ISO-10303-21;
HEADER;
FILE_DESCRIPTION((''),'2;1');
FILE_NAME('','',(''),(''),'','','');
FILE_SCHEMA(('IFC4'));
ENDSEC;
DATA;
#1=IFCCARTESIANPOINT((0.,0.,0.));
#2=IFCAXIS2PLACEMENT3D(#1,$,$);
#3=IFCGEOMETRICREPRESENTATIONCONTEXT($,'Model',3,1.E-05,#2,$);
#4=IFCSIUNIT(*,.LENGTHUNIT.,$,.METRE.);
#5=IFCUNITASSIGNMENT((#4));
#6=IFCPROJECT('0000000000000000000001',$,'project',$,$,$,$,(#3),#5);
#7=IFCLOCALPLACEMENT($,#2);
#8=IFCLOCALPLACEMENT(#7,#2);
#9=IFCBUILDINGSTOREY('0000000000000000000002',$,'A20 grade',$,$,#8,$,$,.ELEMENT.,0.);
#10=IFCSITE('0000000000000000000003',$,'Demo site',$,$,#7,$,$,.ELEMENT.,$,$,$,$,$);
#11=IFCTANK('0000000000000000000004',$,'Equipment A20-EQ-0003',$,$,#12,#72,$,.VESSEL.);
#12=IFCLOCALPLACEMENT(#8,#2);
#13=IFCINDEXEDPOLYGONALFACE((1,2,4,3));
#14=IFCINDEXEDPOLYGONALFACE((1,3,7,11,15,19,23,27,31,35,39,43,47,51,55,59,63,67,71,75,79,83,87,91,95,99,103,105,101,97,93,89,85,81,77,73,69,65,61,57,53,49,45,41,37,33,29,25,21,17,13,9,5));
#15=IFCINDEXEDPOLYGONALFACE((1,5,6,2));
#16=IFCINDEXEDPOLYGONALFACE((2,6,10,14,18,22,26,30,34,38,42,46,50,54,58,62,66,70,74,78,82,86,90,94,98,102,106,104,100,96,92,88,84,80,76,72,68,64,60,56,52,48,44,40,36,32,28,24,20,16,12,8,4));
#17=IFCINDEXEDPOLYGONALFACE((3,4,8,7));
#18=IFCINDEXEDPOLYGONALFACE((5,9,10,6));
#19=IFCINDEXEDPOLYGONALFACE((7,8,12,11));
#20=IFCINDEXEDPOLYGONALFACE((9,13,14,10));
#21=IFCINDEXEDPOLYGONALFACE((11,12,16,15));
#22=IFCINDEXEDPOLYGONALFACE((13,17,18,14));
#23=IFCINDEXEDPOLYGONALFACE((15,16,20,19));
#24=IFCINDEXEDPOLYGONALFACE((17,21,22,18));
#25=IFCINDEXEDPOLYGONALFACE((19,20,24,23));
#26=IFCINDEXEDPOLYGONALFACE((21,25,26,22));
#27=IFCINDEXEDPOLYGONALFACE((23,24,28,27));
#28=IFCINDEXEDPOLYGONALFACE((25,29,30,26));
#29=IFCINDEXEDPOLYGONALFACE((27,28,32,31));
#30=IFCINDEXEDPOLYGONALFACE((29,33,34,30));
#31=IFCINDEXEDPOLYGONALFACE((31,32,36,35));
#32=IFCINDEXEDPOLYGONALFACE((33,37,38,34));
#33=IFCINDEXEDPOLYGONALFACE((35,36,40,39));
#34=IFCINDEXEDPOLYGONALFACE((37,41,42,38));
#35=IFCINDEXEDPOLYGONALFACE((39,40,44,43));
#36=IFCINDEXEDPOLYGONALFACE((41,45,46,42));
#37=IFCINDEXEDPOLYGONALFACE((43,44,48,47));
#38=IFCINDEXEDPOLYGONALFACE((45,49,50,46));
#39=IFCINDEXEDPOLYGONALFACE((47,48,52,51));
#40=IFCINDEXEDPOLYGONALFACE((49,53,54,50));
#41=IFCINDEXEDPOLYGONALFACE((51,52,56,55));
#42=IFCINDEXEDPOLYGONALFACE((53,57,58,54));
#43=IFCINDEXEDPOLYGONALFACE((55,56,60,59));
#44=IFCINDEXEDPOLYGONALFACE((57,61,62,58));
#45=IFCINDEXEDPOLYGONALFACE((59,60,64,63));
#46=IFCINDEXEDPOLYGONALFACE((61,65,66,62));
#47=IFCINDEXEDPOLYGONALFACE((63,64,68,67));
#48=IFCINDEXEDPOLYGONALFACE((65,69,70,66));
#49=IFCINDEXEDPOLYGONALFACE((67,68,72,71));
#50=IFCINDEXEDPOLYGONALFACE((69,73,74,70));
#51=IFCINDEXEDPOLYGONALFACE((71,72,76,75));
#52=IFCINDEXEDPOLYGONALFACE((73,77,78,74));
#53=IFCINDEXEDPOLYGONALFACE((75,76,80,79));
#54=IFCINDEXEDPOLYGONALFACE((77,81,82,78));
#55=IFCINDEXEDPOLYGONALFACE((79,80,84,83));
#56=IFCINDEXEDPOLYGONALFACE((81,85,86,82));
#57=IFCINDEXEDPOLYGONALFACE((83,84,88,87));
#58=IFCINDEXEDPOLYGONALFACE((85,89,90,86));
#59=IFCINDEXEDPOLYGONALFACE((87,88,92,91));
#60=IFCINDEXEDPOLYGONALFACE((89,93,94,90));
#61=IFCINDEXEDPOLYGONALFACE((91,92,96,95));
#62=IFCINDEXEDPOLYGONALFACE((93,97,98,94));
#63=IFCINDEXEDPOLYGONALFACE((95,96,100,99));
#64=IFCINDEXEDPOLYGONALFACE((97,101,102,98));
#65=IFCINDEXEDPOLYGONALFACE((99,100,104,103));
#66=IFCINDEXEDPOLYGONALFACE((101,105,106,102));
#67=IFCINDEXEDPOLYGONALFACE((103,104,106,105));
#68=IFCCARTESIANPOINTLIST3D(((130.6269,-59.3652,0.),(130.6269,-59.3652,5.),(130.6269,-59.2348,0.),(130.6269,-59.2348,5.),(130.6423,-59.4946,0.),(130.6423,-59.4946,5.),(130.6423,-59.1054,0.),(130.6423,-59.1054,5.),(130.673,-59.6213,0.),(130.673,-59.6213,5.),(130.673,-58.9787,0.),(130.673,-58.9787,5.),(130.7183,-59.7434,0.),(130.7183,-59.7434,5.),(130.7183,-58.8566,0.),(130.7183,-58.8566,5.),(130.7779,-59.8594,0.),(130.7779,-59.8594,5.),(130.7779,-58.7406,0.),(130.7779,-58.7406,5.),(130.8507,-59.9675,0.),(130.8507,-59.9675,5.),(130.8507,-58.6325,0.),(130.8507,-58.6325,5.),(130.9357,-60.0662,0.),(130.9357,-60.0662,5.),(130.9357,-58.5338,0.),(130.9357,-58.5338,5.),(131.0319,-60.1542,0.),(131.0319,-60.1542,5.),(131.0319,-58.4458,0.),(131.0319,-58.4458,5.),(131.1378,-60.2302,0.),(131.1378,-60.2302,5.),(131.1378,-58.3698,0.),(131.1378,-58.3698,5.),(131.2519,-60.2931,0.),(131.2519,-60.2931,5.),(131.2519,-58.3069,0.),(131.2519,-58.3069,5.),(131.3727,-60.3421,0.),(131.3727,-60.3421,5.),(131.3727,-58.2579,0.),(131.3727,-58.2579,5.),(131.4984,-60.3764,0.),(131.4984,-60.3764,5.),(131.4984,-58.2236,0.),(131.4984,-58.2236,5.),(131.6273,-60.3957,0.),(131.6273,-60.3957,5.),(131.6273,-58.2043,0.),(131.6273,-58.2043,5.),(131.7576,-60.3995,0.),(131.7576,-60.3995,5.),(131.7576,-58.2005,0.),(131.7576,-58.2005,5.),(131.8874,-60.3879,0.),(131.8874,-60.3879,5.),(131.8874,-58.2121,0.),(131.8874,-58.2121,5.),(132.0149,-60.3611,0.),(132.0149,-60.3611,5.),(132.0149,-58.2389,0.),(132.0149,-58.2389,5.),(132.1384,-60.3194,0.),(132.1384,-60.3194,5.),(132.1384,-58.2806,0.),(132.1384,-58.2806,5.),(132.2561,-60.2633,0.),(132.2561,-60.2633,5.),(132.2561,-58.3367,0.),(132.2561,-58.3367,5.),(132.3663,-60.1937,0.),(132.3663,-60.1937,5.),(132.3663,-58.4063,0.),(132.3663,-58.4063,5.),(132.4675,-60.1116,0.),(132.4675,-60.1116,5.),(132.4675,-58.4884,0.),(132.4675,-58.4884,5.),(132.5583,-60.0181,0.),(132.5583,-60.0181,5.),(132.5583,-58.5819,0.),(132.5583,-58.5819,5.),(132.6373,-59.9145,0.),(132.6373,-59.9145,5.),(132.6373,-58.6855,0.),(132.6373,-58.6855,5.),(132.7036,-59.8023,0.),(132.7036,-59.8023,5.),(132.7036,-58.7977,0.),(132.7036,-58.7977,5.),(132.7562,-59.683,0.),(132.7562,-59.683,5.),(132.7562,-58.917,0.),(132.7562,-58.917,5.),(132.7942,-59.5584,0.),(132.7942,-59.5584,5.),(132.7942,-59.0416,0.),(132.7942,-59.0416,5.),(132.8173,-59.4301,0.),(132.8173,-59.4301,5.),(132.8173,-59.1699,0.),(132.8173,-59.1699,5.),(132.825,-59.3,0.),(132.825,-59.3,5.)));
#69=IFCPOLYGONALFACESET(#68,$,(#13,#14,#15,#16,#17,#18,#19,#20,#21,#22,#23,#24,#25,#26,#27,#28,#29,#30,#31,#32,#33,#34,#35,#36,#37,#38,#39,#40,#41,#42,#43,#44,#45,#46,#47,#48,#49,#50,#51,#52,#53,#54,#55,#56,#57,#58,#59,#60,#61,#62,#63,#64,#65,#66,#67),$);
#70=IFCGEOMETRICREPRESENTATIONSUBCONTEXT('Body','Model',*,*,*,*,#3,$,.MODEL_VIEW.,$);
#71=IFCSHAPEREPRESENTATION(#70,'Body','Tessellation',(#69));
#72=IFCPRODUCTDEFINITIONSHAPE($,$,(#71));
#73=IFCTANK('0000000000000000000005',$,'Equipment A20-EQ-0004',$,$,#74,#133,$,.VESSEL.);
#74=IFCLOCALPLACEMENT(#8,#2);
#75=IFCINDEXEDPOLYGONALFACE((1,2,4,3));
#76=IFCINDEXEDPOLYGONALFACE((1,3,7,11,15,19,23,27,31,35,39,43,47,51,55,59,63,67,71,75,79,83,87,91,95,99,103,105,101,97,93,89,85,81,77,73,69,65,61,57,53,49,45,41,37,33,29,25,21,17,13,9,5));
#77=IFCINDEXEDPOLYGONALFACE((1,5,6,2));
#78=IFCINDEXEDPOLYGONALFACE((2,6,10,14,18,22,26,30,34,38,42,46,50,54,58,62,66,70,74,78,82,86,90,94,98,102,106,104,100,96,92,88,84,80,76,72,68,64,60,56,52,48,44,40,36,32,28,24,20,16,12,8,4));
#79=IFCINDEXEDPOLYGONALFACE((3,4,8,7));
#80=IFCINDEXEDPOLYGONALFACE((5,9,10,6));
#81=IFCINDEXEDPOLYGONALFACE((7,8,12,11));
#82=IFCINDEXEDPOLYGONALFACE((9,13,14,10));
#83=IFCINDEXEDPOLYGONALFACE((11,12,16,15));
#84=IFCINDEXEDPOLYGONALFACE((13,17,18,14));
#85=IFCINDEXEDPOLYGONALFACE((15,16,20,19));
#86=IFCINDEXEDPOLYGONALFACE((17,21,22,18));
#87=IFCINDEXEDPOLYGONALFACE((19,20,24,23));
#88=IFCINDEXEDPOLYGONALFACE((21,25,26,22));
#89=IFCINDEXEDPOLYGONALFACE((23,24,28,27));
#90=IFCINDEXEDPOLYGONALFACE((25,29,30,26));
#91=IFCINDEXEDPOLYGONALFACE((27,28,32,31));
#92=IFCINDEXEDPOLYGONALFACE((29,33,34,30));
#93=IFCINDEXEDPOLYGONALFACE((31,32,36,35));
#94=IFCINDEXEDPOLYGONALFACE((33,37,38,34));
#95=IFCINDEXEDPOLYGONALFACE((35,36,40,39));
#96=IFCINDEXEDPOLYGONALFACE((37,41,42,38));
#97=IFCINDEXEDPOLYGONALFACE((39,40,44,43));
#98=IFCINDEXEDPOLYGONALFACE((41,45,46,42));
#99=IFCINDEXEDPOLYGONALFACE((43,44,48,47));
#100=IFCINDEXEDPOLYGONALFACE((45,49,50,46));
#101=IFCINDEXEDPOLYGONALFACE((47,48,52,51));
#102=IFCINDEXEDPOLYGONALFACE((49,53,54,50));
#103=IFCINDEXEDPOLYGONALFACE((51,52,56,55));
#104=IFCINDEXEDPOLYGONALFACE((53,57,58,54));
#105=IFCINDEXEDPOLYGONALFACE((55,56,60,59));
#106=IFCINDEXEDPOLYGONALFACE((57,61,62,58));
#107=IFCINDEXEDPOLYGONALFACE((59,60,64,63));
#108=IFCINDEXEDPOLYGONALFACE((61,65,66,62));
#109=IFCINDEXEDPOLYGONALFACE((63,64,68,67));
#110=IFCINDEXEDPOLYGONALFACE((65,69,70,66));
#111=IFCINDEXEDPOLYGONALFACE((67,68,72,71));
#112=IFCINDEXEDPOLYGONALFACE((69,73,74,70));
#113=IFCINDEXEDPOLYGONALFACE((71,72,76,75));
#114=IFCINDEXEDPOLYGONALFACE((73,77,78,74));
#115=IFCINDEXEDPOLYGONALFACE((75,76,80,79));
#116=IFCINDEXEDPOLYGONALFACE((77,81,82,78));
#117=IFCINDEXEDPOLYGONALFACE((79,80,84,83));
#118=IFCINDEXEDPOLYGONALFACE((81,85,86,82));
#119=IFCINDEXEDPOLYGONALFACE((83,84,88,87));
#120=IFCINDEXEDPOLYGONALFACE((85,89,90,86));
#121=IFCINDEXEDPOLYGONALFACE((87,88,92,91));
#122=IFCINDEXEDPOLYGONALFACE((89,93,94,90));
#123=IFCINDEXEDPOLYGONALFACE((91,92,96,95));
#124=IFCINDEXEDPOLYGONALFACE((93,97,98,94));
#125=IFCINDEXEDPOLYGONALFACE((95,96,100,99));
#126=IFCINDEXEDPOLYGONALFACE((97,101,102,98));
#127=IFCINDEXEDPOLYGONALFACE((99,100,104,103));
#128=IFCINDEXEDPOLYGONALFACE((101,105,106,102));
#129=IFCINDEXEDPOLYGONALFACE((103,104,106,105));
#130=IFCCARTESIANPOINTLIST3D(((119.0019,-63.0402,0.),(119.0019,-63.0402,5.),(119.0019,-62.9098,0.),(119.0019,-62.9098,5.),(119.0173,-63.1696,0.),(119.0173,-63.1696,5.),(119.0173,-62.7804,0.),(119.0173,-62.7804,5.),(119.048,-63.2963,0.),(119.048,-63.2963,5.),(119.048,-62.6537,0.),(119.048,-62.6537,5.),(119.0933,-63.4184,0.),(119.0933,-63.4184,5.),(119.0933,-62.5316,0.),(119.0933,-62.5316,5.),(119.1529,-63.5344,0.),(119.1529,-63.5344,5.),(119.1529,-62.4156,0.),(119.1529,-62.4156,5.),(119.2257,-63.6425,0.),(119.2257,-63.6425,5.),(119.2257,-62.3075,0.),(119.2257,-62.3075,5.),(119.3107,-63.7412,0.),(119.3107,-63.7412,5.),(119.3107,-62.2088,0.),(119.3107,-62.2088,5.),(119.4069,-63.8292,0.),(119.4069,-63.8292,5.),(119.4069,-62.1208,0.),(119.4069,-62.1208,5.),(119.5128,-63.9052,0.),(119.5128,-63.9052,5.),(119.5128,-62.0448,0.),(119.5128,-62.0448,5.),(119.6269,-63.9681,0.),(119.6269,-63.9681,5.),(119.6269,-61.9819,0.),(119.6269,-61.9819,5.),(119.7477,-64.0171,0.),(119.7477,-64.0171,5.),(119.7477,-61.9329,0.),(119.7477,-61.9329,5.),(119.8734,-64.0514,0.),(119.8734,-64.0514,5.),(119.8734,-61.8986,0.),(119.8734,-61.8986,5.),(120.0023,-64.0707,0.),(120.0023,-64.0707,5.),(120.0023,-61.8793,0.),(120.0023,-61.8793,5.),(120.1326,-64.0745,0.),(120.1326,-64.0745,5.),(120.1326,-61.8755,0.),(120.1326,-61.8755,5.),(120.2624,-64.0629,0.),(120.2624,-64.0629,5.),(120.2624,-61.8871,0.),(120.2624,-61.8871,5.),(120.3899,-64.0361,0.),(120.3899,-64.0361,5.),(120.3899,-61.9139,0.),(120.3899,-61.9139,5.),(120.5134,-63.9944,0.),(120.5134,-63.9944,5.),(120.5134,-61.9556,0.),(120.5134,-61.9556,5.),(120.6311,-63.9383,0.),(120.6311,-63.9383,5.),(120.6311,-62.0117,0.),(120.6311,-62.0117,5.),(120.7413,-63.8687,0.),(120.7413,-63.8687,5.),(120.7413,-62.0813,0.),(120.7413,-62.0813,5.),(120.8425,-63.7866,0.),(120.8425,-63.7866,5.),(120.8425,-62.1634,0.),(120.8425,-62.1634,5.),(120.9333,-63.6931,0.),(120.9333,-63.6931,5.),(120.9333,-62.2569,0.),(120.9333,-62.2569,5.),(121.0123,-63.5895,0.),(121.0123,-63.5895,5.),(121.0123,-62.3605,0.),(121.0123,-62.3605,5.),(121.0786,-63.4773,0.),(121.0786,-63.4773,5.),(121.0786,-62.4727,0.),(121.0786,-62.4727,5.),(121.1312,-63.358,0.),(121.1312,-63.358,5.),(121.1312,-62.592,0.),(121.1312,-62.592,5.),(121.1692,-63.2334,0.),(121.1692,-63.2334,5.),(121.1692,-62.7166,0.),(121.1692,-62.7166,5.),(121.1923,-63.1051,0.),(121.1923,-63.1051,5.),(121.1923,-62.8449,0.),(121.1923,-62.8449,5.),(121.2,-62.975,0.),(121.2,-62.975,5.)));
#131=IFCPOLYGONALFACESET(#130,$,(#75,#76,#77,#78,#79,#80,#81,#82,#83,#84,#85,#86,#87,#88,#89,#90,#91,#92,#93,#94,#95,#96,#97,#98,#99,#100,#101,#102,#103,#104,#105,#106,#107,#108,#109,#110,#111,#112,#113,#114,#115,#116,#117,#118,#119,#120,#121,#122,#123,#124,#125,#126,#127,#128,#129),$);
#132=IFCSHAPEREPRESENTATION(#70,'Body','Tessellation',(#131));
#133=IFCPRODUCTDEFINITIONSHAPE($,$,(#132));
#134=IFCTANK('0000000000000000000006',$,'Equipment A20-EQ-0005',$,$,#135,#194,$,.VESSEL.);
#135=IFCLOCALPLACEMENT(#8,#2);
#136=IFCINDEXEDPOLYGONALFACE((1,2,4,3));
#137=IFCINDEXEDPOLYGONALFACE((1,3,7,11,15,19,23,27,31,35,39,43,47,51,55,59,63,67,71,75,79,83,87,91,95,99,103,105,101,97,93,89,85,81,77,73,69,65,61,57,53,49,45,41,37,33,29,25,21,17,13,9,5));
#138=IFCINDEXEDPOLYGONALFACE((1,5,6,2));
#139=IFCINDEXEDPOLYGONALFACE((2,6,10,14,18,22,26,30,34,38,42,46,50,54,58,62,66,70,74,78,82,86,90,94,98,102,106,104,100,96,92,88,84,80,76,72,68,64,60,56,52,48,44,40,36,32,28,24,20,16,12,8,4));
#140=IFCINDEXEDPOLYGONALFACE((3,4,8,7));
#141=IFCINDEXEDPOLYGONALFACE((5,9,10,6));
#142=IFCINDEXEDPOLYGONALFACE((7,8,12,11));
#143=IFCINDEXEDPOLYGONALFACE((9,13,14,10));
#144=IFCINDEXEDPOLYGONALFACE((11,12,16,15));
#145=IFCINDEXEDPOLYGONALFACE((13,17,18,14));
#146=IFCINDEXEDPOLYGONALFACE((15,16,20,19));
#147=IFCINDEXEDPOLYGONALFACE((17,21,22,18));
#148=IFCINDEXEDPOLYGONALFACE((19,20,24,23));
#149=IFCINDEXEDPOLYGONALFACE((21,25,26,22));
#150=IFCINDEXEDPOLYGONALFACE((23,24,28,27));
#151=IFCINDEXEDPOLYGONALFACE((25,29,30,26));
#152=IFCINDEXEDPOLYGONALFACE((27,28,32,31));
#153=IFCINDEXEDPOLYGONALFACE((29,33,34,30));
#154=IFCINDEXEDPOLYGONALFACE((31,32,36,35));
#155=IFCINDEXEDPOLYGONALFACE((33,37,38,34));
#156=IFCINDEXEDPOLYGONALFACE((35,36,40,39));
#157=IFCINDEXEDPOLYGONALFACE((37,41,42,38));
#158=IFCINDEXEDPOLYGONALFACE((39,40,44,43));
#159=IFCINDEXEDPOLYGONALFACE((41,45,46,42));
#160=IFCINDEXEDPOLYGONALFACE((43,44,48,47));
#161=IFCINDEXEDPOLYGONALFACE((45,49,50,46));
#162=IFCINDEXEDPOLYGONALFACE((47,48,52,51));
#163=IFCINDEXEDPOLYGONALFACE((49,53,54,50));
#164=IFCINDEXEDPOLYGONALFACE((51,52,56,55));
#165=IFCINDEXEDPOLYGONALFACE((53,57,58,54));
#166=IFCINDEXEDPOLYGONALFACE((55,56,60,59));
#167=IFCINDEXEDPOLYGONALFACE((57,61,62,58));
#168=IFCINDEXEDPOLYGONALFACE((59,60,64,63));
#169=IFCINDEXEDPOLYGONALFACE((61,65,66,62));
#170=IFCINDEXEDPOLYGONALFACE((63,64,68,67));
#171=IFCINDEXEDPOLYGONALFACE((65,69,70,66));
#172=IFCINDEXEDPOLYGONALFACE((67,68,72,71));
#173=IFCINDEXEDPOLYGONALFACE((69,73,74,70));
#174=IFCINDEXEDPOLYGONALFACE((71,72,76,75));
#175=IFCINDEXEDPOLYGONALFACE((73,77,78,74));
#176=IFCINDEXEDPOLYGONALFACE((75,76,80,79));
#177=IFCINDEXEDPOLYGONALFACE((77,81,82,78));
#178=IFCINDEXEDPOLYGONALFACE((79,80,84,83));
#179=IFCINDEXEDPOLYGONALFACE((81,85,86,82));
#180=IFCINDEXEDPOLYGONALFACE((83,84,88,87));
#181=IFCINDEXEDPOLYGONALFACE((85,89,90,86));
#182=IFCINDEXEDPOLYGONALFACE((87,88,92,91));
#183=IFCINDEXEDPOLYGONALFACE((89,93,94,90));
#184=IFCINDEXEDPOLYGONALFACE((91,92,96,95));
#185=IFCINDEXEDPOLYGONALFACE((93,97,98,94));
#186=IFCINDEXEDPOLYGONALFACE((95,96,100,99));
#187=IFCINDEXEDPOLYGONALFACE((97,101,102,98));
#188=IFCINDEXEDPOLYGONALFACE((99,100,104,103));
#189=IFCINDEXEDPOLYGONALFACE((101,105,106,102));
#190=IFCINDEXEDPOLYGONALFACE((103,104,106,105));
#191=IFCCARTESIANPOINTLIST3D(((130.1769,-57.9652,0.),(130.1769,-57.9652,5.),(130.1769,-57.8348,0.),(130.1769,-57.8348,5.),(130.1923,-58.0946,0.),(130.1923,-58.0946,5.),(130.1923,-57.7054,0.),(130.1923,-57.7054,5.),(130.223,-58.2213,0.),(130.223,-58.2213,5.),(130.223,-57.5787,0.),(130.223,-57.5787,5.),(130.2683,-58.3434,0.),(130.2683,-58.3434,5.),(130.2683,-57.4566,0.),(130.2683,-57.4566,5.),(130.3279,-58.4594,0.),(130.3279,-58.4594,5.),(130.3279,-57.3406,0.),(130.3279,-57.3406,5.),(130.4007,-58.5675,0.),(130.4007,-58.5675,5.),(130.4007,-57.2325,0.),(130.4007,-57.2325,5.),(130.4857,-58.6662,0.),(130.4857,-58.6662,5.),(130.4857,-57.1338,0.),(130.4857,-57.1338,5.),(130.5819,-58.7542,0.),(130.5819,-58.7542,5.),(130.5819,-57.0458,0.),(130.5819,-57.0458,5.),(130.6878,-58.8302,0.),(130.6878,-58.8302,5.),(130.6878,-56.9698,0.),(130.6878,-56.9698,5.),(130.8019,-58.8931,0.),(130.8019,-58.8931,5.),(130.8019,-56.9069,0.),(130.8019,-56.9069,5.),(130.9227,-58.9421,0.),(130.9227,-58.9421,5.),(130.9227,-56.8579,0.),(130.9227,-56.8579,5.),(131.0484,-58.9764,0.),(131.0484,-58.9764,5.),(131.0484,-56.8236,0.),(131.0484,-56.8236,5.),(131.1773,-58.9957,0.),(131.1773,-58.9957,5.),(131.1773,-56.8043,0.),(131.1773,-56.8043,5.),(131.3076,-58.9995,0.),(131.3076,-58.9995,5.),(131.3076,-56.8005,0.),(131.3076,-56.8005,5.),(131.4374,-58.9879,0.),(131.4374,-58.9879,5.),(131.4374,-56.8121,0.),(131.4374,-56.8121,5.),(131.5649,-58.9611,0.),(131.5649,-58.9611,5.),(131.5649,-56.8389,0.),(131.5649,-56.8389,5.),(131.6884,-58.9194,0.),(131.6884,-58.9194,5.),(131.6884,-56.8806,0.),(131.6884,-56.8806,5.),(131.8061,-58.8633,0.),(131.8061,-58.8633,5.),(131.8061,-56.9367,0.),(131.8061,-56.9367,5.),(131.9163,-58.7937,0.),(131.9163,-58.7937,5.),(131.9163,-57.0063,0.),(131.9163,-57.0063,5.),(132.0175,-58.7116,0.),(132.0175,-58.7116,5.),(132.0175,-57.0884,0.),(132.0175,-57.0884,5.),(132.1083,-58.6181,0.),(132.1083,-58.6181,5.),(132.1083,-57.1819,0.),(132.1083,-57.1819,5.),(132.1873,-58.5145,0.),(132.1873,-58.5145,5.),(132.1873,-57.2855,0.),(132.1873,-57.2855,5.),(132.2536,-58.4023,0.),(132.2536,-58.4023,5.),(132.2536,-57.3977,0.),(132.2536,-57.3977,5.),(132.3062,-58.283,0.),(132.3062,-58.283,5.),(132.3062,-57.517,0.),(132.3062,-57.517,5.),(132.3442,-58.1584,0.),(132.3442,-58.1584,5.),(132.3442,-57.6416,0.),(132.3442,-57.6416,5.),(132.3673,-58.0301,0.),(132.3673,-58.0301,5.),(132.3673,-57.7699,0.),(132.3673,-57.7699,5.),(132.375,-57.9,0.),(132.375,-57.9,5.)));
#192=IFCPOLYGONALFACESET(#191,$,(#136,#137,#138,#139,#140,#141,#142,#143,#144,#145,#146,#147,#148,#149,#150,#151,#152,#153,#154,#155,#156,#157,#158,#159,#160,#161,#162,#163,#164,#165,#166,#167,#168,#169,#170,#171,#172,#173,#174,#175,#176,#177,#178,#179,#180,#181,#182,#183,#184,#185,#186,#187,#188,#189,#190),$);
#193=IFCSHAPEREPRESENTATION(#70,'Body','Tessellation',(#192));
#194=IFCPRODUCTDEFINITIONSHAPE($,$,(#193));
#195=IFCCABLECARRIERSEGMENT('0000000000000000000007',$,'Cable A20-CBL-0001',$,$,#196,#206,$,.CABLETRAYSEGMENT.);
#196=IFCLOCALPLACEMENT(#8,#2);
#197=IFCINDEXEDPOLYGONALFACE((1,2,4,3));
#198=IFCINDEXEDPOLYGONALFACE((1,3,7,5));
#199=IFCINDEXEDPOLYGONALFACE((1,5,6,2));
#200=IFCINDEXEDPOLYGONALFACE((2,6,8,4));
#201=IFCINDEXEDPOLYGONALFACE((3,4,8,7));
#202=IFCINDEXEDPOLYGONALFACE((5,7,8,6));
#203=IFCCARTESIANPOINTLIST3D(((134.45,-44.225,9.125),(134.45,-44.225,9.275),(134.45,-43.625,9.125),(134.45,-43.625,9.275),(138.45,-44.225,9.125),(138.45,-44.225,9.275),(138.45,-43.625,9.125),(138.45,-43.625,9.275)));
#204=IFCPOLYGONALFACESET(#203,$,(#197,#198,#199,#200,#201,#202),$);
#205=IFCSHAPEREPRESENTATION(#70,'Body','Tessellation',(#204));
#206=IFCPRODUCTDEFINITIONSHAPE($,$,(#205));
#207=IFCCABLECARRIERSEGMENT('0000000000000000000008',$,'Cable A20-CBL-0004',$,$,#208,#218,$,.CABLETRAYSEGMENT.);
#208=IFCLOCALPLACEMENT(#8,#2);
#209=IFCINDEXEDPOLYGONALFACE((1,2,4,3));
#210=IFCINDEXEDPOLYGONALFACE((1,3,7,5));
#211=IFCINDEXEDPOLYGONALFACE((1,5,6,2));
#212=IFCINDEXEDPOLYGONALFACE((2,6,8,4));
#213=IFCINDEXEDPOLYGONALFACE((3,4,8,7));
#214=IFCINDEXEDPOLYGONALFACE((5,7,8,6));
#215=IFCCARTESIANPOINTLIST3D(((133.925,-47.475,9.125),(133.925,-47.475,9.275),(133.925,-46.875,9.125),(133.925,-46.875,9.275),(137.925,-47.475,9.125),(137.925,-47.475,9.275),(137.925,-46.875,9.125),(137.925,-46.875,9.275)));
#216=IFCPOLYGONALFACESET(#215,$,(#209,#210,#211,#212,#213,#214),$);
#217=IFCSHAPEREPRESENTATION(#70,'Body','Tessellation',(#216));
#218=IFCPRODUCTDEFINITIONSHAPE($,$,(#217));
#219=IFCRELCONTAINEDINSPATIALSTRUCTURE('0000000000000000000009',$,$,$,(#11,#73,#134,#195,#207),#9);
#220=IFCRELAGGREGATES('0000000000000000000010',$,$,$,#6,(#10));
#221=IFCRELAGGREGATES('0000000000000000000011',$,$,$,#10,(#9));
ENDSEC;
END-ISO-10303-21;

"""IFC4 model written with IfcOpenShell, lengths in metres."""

from ifc_helpers import new_model, si_unit, frame, origin, place, context, subcontext, project, spatial, rectangle, circle, extrude, element, save


model = new_model("IFC4")

# Units and contexts
model_context = context("Model", 3, precision=1e-05, world=origin())
body_context = subcontext(model_context, "Body", "Model", "MODEL_VIEW")
ifc_project = project(units=[si_unit("LENGTHUNIT", "METRE")], contexts=[model_context])

# Site, storey
site_placement = place(None, origin())
site = spatial("IfcSite", under=ifc_project, at=site_placement, Name="Demo site", CompositionType="ELEMENT")
storey_placement = place(site_placement, origin())
storey = spatial("IfcBuildingStorey", under=site, at=storey_placement, Name="A20 grade", CompositionType="ELEMENT", Elevation=0.0)

# Tanks
for number, where, name in (
    (1, (131.725, -59.3, 0.0), "Equipment A20-EQ-0003"),
    (2, (120.1, -62.975, 0.0), "Equipment A20-EQ-0004"),
    (3, (131.275, -57.9, 0.0), "Equipment A20-EQ-0005"),
):
    element("IfcTank", number, at=place(storey_placement, frame(where)), inside=storey, Name=name, PredefinedType="VESSEL", context=body_context, shape_type="SweptSolid", body=[
        extrude(circle(Radius=1.1), origin(), (0.0, 0.0, 1.0), 5.0),
    ])

# Cable carrier segments
for number, where, name in (
    (4, (134.45, -43.925, 9.2), "Cable A20-CBL-0001"),
    (5, (133.925, -47.175, 9.2), "Cable A20-CBL-0004"),
):
    element("IfcCableCarrierSegment", number, at=place(storey_placement, frame(where)), inside=storey, Name=name, PredefinedType="CABLETRAYSEGMENT", context=body_context, shape_type="SweptSolid", body=[
        extrude(rectangle(XDim=0.6, YDim=0.15), frame((0.0, 0.0, 0.0), z_axis=(1.0, 0.0, 0.0), x_axis=(0.0, 1.0, 0.0)), (0.0, 0.0, 1.0), 4.0),
    ])

save(model, "model.ifc")
